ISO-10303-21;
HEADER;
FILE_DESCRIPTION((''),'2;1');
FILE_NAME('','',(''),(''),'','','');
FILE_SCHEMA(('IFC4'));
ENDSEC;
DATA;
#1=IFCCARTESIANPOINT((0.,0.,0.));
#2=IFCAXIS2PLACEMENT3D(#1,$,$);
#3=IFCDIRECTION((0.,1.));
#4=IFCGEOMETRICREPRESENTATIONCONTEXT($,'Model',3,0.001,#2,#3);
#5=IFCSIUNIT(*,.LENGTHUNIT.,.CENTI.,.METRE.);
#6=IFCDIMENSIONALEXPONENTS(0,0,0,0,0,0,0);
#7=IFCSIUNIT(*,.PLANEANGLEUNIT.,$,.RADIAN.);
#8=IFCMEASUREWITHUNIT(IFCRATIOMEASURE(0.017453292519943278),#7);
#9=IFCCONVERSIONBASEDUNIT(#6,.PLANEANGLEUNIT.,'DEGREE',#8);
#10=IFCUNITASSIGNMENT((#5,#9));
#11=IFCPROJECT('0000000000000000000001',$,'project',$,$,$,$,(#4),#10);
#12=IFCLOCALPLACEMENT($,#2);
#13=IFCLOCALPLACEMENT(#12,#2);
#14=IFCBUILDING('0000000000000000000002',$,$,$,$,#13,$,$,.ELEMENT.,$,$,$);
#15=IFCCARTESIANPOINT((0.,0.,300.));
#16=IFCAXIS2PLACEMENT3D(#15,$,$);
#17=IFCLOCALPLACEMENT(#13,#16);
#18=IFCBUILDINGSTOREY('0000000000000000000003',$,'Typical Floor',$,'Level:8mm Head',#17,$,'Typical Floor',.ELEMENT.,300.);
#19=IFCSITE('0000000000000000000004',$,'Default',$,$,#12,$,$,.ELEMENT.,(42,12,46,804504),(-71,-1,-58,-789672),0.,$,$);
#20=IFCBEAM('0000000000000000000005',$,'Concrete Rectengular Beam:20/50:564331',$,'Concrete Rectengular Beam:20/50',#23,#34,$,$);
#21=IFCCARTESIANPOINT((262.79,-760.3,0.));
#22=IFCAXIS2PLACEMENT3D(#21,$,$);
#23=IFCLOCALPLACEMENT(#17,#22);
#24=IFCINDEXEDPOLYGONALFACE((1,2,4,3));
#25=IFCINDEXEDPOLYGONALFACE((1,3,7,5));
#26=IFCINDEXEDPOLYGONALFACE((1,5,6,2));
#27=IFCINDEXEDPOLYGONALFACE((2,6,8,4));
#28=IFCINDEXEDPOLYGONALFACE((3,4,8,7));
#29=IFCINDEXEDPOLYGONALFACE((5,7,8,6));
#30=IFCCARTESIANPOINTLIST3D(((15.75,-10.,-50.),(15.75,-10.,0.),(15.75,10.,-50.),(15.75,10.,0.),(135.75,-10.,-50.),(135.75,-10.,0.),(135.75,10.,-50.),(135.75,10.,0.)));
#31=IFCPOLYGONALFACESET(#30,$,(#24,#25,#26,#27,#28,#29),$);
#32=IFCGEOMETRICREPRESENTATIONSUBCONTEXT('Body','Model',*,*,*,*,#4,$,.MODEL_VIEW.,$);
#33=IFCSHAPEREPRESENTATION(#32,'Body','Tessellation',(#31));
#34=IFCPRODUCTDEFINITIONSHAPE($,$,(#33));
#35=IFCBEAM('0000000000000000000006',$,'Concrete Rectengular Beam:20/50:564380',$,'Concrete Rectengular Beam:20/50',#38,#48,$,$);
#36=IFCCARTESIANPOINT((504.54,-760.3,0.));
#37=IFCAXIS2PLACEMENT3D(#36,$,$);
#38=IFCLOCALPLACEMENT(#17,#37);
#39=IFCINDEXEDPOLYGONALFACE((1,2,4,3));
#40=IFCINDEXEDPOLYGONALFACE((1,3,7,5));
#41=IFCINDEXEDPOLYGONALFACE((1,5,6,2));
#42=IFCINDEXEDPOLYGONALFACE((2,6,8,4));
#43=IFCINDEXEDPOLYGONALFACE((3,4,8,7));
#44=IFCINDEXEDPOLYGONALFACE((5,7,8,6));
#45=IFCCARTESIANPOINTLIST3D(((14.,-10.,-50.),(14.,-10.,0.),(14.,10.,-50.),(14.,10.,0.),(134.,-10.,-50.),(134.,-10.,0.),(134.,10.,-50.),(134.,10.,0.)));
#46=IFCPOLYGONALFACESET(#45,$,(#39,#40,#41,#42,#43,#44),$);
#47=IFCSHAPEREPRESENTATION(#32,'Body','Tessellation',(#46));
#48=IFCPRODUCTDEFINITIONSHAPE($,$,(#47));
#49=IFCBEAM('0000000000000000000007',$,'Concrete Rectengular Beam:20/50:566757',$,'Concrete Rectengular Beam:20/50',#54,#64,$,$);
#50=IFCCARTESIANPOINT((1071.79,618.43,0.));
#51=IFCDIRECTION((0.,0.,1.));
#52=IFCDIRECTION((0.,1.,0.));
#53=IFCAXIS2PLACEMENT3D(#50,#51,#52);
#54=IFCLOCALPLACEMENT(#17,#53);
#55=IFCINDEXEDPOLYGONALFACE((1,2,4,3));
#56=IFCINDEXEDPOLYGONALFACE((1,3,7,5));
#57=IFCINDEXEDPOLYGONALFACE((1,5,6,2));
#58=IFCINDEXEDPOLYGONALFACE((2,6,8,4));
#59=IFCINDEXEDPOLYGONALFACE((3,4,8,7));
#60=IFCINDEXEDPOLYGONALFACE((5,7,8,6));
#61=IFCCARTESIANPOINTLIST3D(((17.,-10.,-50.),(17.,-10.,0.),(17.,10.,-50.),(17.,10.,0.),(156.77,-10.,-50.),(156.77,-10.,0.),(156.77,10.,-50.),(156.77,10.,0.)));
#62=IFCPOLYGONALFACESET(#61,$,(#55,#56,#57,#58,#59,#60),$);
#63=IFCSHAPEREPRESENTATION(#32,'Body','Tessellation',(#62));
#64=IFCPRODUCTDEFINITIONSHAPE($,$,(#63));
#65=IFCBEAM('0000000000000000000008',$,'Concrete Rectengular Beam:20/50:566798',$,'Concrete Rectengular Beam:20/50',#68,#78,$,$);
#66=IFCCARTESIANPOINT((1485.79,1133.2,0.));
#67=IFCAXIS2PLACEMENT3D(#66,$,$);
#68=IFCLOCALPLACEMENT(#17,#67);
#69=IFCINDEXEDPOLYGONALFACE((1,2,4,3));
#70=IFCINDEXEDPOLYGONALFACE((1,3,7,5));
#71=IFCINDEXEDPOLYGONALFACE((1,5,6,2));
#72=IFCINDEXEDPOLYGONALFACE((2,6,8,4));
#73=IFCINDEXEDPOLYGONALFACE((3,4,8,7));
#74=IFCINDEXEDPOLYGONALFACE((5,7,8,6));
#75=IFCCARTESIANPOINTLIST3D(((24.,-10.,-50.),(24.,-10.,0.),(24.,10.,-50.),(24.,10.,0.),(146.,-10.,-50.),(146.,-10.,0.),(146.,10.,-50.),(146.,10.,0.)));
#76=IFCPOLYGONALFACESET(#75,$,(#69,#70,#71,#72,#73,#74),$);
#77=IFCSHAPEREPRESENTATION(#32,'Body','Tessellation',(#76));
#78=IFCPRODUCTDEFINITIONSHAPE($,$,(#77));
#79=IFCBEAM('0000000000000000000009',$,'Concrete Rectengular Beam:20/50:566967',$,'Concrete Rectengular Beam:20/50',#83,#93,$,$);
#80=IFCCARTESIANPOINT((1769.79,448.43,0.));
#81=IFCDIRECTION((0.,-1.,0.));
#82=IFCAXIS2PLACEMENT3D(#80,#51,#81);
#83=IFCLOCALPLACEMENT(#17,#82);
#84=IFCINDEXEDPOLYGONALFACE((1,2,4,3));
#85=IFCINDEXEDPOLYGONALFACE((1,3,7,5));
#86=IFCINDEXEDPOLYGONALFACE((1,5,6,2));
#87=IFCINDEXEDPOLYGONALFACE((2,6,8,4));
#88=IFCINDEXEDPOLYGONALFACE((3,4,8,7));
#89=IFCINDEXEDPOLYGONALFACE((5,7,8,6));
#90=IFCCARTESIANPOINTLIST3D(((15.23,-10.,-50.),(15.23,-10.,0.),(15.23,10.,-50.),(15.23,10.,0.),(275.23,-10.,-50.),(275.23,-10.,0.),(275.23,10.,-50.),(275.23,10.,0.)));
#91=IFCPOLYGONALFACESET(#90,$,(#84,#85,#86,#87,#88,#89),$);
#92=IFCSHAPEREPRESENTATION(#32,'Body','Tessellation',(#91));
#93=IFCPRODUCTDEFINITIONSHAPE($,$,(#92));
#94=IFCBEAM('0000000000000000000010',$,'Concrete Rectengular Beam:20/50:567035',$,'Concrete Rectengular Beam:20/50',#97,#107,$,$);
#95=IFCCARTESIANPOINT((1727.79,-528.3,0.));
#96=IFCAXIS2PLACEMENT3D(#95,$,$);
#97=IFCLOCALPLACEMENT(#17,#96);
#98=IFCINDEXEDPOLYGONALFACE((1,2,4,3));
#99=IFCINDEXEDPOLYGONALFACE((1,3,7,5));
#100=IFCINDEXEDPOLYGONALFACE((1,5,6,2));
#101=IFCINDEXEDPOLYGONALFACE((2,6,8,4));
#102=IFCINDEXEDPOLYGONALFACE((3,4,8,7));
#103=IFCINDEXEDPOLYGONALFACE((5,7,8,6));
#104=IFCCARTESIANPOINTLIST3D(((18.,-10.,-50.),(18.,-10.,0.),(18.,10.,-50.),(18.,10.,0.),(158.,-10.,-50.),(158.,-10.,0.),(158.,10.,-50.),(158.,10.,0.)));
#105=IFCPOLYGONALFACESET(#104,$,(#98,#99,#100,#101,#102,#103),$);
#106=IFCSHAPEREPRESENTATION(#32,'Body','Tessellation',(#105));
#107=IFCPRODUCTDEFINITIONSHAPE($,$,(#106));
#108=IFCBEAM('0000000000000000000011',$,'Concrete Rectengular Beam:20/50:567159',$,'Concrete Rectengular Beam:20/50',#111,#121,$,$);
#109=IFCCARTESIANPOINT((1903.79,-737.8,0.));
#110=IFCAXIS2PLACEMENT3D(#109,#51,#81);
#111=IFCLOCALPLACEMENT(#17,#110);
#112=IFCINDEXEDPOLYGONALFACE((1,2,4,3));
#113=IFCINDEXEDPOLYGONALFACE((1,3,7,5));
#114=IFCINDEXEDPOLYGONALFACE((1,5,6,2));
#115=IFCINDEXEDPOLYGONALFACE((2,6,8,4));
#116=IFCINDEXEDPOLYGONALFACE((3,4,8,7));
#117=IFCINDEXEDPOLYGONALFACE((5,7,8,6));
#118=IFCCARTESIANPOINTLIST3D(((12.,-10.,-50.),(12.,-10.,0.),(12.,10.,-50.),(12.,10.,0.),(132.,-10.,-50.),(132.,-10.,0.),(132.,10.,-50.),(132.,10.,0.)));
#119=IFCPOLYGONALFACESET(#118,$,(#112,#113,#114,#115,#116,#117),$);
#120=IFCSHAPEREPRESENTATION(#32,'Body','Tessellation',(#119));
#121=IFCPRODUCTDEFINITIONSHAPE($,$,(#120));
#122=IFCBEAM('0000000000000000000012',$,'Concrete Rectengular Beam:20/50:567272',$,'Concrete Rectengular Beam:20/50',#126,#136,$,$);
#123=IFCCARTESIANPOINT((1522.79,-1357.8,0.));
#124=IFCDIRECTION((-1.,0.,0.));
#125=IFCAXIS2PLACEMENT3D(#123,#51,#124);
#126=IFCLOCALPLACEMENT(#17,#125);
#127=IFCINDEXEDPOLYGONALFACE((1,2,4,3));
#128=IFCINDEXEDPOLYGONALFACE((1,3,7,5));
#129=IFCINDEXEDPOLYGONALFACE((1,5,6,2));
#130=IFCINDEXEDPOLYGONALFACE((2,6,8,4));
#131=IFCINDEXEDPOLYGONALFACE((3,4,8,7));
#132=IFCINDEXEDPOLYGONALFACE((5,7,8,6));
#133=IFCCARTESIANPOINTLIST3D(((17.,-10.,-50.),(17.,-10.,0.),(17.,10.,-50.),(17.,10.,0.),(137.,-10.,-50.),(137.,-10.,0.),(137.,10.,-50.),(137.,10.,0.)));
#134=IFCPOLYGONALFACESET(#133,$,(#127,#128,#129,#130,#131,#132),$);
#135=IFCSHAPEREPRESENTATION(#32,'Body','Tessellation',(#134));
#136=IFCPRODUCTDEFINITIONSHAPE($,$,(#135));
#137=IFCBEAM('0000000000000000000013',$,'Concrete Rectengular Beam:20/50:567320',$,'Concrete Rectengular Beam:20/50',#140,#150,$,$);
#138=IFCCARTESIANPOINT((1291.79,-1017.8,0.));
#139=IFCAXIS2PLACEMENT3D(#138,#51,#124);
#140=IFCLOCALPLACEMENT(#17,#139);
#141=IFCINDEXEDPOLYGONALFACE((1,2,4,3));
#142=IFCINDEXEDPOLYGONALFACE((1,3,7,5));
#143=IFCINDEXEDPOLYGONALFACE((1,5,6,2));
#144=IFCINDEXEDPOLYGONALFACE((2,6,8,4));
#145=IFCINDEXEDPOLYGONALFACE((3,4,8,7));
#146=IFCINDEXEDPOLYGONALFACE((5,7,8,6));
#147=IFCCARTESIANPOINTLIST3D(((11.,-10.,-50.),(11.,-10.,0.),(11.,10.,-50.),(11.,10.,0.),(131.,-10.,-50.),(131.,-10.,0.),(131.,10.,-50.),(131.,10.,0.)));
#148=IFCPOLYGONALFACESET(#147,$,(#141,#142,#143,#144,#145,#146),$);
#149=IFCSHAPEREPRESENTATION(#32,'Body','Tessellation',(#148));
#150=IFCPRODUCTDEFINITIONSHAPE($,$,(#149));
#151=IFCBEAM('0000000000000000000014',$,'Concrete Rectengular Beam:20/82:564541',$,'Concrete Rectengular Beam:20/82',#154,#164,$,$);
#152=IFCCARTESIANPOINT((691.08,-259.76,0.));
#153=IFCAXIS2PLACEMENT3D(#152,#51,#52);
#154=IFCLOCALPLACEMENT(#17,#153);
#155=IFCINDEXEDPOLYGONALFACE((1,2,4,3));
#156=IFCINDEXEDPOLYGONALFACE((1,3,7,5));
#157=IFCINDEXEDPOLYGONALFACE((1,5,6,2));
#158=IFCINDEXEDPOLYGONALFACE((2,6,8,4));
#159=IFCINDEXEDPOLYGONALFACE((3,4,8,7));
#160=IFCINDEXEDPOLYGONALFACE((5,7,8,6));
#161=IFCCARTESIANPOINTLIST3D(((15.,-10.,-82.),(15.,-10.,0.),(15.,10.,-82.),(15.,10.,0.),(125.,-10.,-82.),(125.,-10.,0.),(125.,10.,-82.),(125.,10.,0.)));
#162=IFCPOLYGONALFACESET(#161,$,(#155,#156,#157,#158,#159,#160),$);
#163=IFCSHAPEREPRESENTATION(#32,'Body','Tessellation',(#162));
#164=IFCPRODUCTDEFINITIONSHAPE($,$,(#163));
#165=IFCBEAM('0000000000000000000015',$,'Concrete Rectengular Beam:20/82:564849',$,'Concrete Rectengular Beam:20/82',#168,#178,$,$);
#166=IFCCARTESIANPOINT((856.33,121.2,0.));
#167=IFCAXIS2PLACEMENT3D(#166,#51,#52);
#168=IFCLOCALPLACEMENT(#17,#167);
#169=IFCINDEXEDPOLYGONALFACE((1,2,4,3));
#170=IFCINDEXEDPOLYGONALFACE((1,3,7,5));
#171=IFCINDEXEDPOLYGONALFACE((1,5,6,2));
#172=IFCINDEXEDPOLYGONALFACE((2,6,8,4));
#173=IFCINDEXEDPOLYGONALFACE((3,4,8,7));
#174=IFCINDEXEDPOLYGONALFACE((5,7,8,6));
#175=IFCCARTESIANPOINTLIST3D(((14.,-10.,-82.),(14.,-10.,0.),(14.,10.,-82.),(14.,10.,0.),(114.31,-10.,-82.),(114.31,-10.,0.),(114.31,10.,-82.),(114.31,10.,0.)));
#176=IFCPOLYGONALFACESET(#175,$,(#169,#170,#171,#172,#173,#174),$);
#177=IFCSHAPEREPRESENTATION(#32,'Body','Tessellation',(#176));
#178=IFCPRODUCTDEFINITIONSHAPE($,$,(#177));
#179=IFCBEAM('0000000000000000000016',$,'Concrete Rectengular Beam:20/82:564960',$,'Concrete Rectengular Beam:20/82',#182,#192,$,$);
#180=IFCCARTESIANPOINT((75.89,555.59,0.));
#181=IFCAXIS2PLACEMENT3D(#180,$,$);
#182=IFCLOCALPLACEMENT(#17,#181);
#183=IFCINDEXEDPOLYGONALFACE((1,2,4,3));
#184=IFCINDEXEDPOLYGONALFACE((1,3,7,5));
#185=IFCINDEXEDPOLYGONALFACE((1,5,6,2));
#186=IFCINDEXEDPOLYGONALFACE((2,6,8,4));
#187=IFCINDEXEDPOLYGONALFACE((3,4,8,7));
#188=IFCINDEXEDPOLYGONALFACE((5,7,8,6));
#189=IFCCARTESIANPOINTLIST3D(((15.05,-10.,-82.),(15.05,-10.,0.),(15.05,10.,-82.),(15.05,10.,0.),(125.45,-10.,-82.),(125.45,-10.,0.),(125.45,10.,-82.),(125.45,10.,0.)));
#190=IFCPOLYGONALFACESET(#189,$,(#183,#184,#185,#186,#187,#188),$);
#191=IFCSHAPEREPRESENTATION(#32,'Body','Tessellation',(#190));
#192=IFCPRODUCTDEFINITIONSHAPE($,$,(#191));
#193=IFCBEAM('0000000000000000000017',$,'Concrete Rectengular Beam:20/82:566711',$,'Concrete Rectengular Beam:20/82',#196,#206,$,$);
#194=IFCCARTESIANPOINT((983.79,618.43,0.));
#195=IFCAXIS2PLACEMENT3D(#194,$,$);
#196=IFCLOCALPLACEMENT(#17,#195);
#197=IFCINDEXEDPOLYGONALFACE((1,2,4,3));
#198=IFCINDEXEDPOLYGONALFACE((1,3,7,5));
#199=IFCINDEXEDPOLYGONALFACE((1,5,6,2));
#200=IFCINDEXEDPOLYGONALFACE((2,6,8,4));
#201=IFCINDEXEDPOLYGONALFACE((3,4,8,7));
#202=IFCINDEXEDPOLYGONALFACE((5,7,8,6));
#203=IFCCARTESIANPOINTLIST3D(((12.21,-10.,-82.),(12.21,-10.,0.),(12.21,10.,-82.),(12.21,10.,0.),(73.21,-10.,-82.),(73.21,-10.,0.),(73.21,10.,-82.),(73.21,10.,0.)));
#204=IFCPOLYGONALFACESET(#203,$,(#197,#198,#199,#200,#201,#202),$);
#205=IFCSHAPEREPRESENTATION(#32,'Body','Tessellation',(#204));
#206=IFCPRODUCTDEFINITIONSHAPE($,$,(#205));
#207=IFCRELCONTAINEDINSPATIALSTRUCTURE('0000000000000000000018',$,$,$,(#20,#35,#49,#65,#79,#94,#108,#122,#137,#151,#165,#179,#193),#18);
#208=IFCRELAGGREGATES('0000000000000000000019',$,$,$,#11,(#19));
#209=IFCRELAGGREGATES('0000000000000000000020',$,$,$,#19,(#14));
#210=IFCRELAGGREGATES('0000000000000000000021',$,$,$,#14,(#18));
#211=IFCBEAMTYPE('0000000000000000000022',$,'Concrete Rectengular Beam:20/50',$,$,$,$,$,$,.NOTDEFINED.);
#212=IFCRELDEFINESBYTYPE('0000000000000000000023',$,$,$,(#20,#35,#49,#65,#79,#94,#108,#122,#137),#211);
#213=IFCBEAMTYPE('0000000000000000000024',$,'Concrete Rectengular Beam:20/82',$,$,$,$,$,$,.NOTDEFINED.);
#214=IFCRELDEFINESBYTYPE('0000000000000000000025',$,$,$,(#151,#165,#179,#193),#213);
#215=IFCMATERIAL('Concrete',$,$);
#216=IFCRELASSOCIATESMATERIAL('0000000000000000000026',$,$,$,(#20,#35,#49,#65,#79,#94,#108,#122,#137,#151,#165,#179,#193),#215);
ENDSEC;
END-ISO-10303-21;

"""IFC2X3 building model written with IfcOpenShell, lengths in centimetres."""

from ifc_helpers import new_model, entity, si_unit, converted_unit, direction, frame, frame_2d, origin, origin_2d_with_axis, place, context, subcontext, project, spatial, rectangle, extrude, material, type_object, element, save


model = new_model("IFC2X3")

# Units and contexts
model_context = context("Model", 3, precision=0.001, world=origin(), true_north=direction((0.0, 1.0)))
body_context = subcontext(model_context, "Body", "Model", "MODEL_VIEW")
ifc_project = project(units=[si_unit("LENGTHUNIT", "METRE", prefix="CENTI"), converted_unit("PLANEANGLEUNIT", "DEGREE", entity("IfcRatioMeasure", 0.017453292519943278), si_unit("PLANEANGLEUNIT", "RADIAN"), dimensions=[0, 0, 0, 0, 0, 0, 0])], contexts=[model_context])

# Site, building, storey
site_placement = place(None, origin())
site = spatial("IfcSite", under=ifc_project, at=site_placement, Name="Default", CompositionType="ELEMENT", RefLatitude=(42, 12, 46, 804504), RefLongitude=(-71, -1, -58, -789672), RefElevation=0.0)
building_placement = place(site_placement, origin())
building = spatial("IfcBuilding", under=site, at=building_placement, CompositionType="ELEMENT")
storey_placement = place(building_placement, frame((0.0, 0.0, 300.0)))
storey = spatial("IfcBuildingStorey", under=building, at=storey_placement, Name="Typical Floor", ObjectType="Level:8mm Head", LongName="Typical Floor", CompositionType="ELEMENT", Elevation=300.0)

# Beams
ifc_material = material(Name="Concrete")
beam_type_1 = type_object("IfcBeamType", Name="Concrete Rectengular Beam:20/50", PredefinedType="NOTDEFINED")
beam_1_placement = place(storey_placement, frame((262.79, -760.3, 0.0)))
element("IfcBeam", 1, at=beam_1_placement, inside=storey, type_object=beam_type_1, material=ifc_material, Name="Concrete Rectengular Beam:20/50:564331", ObjectType="Concrete Rectengular Beam:20/50", context=body_context, shape_type="SweptSolid", body=[
    extrude(rectangle(XDim=50.0, YDim=20.0, at=frame_2d((0.0, 0.0), x_axis=(1.0, 0.0))), frame((15.75, 0.0, -25.0), z_axis=(1.0, 0.0, 0.0), x_axis=(0.0, 0.0, -1.0)), (0.0, 0.0, 1.0), 120.0),
])
beam_2_placement = place(storey_placement, frame((504.54, -760.3, 0.0)))
element("IfcBeam", 2, at=beam_2_placement, inside=storey, type_object=beam_type_1, material=ifc_material, Name="Concrete Rectengular Beam:20/50:564380", ObjectType="Concrete Rectengular Beam:20/50", context=body_context, shape_type="SweptSolid", body=[
    extrude(rectangle(XDim=50.0, YDim=20.0, at=origin_2d_with_axis()), frame((14.0, 0.0, -25.0), z_axis=(1.0, 0.0, 0.0), x_axis=(0.0, 0.0, -1.0)), (0.0, 0.0, 1.0), 120.0),
])
beam_3_placement = place(storey_placement, frame((1071.79, 618.43, 0.0), z_axis=(0.0, 0.0, 1.0), x_axis=(0.0, 1.0, 0.0)))
element("IfcBeam", 3, at=beam_3_placement, inside=storey, type_object=beam_type_1, material=ifc_material, Name="Concrete Rectengular Beam:20/50:566757", ObjectType="Concrete Rectengular Beam:20/50", context=body_context, shape_type="SweptSolid", body=[
    extrude(rectangle(XDim=50.0, YDim=20.0, at=frame_2d((0.0, 0.0), x_axis=(1.0, 0.0))), frame((17.0, 0.0, -25.0), z_axis=(1.0, 0.0, 0.0), x_axis=(0.0, 0.0, -1.0)), (0.0, 0.0, 1.0), 139.77),
])
beam_4_placement = place(storey_placement, frame((1485.79, 1133.2, 0.0)))
element("IfcBeam", 4, at=beam_4_placement, inside=storey, type_object=beam_type_1, material=ifc_material, Name="Concrete Rectengular Beam:20/50:566798", ObjectType="Concrete Rectengular Beam:20/50", context=body_context, shape_type="SweptSolid", body=[
    extrude(rectangle(XDim=50.0, YDim=20.0, at=origin_2d_with_axis()), frame((24.0, 0.0, -25.0), z_axis=(1.0, 0.0, 0.0), x_axis=(0.0, 0.0, -1.0)), (0.0, 0.0, 1.0), 122.0),
])
beam_5_placement = place(storey_placement, frame((1769.79, 448.43, 0.0), z_axis=(0.0, 0.0, 1.0), x_axis=(0.0, -1.0, 0.0)))
element("IfcBeam", 5, at=beam_5_placement, inside=storey, type_object=beam_type_1, material=ifc_material, Name="Concrete Rectengular Beam:20/50:566967", ObjectType="Concrete Rectengular Beam:20/50", context=body_context, shape_type="SweptSolid", body=[
    extrude(rectangle(XDim=50.0, YDim=20.0, at=origin_2d_with_axis()), frame((15.23, 0.0, -25.0), z_axis=(1.0, 0.0, 0.0), x_axis=(0.0, 0.0, -1.0)), (0.0, 0.0, 1.0), 260.0),
])
beam_6_placement = place(storey_placement, frame((1727.79, -528.3, 0.0)))
element("IfcBeam", 6, at=beam_6_placement, inside=storey, type_object=beam_type_1, material=ifc_material, Name="Concrete Rectengular Beam:20/50:567035", ObjectType="Concrete Rectengular Beam:20/50", context=body_context, shape_type="SweptSolid", body=[
    extrude(rectangle(XDim=50.0, YDim=20.0, at=frame_2d((0.0, 0.0), x_axis=(1.0, 0.0))), frame((18.0, 0.0, -25.0), z_axis=(1.0, 0.0, 0.0), x_axis=(0.0, 0.0, -1.0)), (0.0, 0.0, 1.0), 140.0),
])
beam_7_placement = place(storey_placement, frame((1903.79, -737.8, 0.0), z_axis=(0.0, 0.0, 1.0), x_axis=(0.0, -1.0, 0.0)))
element("IfcBeam", 7, at=beam_7_placement, inside=storey, type_object=beam_type_1, material=ifc_material, Name="Concrete Rectengular Beam:20/50:567159", ObjectType="Concrete Rectengular Beam:20/50", context=body_context, shape_type="SweptSolid", body=[
    extrude(rectangle(XDim=50.0, YDim=20.0, at=frame_2d((0.0, 0.0), x_axis=(1.0, 0.0))), frame((12.0, 0.0, -25.0), z_axis=(1.0, 0.0, 0.0), x_axis=(0.0, 0.0, -1.0)), (0.0, 0.0, 1.0), 120.0),
])
beam_8_placement = place(storey_placement, frame((1522.79, -1357.8, 0.0), z_axis=(0.0, 0.0, 1.0), x_axis=(-1.0, 0.0, 0.0)))
element("IfcBeam", 8, at=beam_8_placement, inside=storey, type_object=beam_type_1, material=ifc_material, Name="Concrete Rectengular Beam:20/50:567272", ObjectType="Concrete Rectengular Beam:20/50", context=body_context, shape_type="SweptSolid", body=[
    extrude(rectangle(XDim=50.0, YDim=20.0, at=frame_2d((0.0, 0.0), x_axis=(1.0, 0.0))), frame((17.0, 0.0, -25.0), z_axis=(1.0, 0.0, 0.0), x_axis=(0.0, 0.0, -1.0)), (0.0, 0.0, 1.0), 120.0),
])
beam_9_placement = place(storey_placement, frame((1291.79, -1017.8, 0.0), z_axis=(0.0, 0.0, 1.0), x_axis=(-1.0, 0.0, 0.0)))
element("IfcBeam", 9, at=beam_9_placement, inside=storey, type_object=beam_type_1, material=ifc_material, Name="Concrete Rectengular Beam:20/50:567320", ObjectType="Concrete Rectengular Beam:20/50", context=body_context, shape_type="SweptSolid", body=[
    extrude(rectangle(XDim=50.0, YDim=20.0, at=frame_2d((0.0, 0.0), x_axis=(1.0, 0.0))), frame((11.0, 0.0, -25.0), z_axis=(1.0, 0.0, 0.0), x_axis=(0.0, 0.0, -1.0)), (0.0, 0.0, 1.0), 120.0),
])
beam_type_2 = type_object("IfcBeamType", Name="Concrete Rectengular Beam:20/82", PredefinedType="NOTDEFINED")
beam_10_placement = place(storey_placement, frame((691.08, -259.76, 0.0), z_axis=(0.0, 0.0, 1.0), x_axis=(0.0, 1.0, 0.0)))
element("IfcBeam", 10, at=beam_10_placement, inside=storey, type_object=beam_type_2, material=ifc_material, Name="Concrete Rectengular Beam:20/82:564541", ObjectType="Concrete Rectengular Beam:20/82", context=body_context, shape_type="SweptSolid", body=[
    extrude(rectangle(XDim=82.0, YDim=20.0, at=origin_2d_with_axis()), frame((15.0, 0.0, -41.0), z_axis=(1.0, 0.0, 0.0), x_axis=(0.0, 0.0, -1.0)), (0.0, 0.0, 1.0), 110.0),
])
beam_11_placement = place(storey_placement, frame((856.33, 121.2, 0.0), z_axis=(0.0, 0.0, 1.0), x_axis=(0.0, 1.0, 0.0)))
element("IfcBeam", 11, at=beam_11_placement, inside=storey, type_object=beam_type_2, material=ifc_material, Name="Concrete Rectengular Beam:20/82:564849", ObjectType="Concrete Rectengular Beam:20/82", context=body_context, shape_type="SweptSolid", body=[
    extrude(rectangle(XDim=82.0, YDim=20.0, at=frame_2d((0.0, 0.0), x_axis=(1.0, 0.0))), frame((14.0, 0.0, -41.0), z_axis=(1.0, 0.0, 0.0), x_axis=(0.0, 0.0, -1.0)), (0.0, 0.0, 1.0), 100.31),
])
beam_12_placement = place(storey_placement, frame((75.89, 555.59, 0.0)))
element("IfcBeam", 12, at=beam_12_placement, inside=storey, type_object=beam_type_2, material=ifc_material, Name="Concrete Rectengular Beam:20/82:564960", ObjectType="Concrete Rectengular Beam:20/82", context=body_context, shape_type="SweptSolid", body=[
    extrude(rectangle(XDim=82.0, YDim=20.0, at=frame_2d((0.0, 0.0), x_axis=(1.0, 0.0))), frame((15.05, 0.0, -41.0), z_axis=(1.0, 0.0, 0.0), x_axis=(0.0, 0.0, -1.0)), (0.0, 0.0, 1.0), 110.39),
])
beam_13_placement = place(storey_placement, frame((983.79, 618.43, 0.0)))
element("IfcBeam", 13, at=beam_13_placement, inside=storey, type_object=beam_type_2, material=ifc_material, Name="Concrete Rectengular Beam:20/82:566711", ObjectType="Concrete Rectengular Beam:20/82", context=body_context, shape_type="SweptSolid", body=[
    extrude(rectangle(XDim=82.0, YDim=20.0, at=frame_2d((0.0, 0.0), x_axis=(1.0, 0.0))), frame((12.21, 0.0, -41.0), z_axis=(1.0, 0.0, 0.0), x_axis=(0.0, 0.0, -1.0)), (0.0, 0.0, 1.0), 61.0),
])

save(model, "model.ifc")
